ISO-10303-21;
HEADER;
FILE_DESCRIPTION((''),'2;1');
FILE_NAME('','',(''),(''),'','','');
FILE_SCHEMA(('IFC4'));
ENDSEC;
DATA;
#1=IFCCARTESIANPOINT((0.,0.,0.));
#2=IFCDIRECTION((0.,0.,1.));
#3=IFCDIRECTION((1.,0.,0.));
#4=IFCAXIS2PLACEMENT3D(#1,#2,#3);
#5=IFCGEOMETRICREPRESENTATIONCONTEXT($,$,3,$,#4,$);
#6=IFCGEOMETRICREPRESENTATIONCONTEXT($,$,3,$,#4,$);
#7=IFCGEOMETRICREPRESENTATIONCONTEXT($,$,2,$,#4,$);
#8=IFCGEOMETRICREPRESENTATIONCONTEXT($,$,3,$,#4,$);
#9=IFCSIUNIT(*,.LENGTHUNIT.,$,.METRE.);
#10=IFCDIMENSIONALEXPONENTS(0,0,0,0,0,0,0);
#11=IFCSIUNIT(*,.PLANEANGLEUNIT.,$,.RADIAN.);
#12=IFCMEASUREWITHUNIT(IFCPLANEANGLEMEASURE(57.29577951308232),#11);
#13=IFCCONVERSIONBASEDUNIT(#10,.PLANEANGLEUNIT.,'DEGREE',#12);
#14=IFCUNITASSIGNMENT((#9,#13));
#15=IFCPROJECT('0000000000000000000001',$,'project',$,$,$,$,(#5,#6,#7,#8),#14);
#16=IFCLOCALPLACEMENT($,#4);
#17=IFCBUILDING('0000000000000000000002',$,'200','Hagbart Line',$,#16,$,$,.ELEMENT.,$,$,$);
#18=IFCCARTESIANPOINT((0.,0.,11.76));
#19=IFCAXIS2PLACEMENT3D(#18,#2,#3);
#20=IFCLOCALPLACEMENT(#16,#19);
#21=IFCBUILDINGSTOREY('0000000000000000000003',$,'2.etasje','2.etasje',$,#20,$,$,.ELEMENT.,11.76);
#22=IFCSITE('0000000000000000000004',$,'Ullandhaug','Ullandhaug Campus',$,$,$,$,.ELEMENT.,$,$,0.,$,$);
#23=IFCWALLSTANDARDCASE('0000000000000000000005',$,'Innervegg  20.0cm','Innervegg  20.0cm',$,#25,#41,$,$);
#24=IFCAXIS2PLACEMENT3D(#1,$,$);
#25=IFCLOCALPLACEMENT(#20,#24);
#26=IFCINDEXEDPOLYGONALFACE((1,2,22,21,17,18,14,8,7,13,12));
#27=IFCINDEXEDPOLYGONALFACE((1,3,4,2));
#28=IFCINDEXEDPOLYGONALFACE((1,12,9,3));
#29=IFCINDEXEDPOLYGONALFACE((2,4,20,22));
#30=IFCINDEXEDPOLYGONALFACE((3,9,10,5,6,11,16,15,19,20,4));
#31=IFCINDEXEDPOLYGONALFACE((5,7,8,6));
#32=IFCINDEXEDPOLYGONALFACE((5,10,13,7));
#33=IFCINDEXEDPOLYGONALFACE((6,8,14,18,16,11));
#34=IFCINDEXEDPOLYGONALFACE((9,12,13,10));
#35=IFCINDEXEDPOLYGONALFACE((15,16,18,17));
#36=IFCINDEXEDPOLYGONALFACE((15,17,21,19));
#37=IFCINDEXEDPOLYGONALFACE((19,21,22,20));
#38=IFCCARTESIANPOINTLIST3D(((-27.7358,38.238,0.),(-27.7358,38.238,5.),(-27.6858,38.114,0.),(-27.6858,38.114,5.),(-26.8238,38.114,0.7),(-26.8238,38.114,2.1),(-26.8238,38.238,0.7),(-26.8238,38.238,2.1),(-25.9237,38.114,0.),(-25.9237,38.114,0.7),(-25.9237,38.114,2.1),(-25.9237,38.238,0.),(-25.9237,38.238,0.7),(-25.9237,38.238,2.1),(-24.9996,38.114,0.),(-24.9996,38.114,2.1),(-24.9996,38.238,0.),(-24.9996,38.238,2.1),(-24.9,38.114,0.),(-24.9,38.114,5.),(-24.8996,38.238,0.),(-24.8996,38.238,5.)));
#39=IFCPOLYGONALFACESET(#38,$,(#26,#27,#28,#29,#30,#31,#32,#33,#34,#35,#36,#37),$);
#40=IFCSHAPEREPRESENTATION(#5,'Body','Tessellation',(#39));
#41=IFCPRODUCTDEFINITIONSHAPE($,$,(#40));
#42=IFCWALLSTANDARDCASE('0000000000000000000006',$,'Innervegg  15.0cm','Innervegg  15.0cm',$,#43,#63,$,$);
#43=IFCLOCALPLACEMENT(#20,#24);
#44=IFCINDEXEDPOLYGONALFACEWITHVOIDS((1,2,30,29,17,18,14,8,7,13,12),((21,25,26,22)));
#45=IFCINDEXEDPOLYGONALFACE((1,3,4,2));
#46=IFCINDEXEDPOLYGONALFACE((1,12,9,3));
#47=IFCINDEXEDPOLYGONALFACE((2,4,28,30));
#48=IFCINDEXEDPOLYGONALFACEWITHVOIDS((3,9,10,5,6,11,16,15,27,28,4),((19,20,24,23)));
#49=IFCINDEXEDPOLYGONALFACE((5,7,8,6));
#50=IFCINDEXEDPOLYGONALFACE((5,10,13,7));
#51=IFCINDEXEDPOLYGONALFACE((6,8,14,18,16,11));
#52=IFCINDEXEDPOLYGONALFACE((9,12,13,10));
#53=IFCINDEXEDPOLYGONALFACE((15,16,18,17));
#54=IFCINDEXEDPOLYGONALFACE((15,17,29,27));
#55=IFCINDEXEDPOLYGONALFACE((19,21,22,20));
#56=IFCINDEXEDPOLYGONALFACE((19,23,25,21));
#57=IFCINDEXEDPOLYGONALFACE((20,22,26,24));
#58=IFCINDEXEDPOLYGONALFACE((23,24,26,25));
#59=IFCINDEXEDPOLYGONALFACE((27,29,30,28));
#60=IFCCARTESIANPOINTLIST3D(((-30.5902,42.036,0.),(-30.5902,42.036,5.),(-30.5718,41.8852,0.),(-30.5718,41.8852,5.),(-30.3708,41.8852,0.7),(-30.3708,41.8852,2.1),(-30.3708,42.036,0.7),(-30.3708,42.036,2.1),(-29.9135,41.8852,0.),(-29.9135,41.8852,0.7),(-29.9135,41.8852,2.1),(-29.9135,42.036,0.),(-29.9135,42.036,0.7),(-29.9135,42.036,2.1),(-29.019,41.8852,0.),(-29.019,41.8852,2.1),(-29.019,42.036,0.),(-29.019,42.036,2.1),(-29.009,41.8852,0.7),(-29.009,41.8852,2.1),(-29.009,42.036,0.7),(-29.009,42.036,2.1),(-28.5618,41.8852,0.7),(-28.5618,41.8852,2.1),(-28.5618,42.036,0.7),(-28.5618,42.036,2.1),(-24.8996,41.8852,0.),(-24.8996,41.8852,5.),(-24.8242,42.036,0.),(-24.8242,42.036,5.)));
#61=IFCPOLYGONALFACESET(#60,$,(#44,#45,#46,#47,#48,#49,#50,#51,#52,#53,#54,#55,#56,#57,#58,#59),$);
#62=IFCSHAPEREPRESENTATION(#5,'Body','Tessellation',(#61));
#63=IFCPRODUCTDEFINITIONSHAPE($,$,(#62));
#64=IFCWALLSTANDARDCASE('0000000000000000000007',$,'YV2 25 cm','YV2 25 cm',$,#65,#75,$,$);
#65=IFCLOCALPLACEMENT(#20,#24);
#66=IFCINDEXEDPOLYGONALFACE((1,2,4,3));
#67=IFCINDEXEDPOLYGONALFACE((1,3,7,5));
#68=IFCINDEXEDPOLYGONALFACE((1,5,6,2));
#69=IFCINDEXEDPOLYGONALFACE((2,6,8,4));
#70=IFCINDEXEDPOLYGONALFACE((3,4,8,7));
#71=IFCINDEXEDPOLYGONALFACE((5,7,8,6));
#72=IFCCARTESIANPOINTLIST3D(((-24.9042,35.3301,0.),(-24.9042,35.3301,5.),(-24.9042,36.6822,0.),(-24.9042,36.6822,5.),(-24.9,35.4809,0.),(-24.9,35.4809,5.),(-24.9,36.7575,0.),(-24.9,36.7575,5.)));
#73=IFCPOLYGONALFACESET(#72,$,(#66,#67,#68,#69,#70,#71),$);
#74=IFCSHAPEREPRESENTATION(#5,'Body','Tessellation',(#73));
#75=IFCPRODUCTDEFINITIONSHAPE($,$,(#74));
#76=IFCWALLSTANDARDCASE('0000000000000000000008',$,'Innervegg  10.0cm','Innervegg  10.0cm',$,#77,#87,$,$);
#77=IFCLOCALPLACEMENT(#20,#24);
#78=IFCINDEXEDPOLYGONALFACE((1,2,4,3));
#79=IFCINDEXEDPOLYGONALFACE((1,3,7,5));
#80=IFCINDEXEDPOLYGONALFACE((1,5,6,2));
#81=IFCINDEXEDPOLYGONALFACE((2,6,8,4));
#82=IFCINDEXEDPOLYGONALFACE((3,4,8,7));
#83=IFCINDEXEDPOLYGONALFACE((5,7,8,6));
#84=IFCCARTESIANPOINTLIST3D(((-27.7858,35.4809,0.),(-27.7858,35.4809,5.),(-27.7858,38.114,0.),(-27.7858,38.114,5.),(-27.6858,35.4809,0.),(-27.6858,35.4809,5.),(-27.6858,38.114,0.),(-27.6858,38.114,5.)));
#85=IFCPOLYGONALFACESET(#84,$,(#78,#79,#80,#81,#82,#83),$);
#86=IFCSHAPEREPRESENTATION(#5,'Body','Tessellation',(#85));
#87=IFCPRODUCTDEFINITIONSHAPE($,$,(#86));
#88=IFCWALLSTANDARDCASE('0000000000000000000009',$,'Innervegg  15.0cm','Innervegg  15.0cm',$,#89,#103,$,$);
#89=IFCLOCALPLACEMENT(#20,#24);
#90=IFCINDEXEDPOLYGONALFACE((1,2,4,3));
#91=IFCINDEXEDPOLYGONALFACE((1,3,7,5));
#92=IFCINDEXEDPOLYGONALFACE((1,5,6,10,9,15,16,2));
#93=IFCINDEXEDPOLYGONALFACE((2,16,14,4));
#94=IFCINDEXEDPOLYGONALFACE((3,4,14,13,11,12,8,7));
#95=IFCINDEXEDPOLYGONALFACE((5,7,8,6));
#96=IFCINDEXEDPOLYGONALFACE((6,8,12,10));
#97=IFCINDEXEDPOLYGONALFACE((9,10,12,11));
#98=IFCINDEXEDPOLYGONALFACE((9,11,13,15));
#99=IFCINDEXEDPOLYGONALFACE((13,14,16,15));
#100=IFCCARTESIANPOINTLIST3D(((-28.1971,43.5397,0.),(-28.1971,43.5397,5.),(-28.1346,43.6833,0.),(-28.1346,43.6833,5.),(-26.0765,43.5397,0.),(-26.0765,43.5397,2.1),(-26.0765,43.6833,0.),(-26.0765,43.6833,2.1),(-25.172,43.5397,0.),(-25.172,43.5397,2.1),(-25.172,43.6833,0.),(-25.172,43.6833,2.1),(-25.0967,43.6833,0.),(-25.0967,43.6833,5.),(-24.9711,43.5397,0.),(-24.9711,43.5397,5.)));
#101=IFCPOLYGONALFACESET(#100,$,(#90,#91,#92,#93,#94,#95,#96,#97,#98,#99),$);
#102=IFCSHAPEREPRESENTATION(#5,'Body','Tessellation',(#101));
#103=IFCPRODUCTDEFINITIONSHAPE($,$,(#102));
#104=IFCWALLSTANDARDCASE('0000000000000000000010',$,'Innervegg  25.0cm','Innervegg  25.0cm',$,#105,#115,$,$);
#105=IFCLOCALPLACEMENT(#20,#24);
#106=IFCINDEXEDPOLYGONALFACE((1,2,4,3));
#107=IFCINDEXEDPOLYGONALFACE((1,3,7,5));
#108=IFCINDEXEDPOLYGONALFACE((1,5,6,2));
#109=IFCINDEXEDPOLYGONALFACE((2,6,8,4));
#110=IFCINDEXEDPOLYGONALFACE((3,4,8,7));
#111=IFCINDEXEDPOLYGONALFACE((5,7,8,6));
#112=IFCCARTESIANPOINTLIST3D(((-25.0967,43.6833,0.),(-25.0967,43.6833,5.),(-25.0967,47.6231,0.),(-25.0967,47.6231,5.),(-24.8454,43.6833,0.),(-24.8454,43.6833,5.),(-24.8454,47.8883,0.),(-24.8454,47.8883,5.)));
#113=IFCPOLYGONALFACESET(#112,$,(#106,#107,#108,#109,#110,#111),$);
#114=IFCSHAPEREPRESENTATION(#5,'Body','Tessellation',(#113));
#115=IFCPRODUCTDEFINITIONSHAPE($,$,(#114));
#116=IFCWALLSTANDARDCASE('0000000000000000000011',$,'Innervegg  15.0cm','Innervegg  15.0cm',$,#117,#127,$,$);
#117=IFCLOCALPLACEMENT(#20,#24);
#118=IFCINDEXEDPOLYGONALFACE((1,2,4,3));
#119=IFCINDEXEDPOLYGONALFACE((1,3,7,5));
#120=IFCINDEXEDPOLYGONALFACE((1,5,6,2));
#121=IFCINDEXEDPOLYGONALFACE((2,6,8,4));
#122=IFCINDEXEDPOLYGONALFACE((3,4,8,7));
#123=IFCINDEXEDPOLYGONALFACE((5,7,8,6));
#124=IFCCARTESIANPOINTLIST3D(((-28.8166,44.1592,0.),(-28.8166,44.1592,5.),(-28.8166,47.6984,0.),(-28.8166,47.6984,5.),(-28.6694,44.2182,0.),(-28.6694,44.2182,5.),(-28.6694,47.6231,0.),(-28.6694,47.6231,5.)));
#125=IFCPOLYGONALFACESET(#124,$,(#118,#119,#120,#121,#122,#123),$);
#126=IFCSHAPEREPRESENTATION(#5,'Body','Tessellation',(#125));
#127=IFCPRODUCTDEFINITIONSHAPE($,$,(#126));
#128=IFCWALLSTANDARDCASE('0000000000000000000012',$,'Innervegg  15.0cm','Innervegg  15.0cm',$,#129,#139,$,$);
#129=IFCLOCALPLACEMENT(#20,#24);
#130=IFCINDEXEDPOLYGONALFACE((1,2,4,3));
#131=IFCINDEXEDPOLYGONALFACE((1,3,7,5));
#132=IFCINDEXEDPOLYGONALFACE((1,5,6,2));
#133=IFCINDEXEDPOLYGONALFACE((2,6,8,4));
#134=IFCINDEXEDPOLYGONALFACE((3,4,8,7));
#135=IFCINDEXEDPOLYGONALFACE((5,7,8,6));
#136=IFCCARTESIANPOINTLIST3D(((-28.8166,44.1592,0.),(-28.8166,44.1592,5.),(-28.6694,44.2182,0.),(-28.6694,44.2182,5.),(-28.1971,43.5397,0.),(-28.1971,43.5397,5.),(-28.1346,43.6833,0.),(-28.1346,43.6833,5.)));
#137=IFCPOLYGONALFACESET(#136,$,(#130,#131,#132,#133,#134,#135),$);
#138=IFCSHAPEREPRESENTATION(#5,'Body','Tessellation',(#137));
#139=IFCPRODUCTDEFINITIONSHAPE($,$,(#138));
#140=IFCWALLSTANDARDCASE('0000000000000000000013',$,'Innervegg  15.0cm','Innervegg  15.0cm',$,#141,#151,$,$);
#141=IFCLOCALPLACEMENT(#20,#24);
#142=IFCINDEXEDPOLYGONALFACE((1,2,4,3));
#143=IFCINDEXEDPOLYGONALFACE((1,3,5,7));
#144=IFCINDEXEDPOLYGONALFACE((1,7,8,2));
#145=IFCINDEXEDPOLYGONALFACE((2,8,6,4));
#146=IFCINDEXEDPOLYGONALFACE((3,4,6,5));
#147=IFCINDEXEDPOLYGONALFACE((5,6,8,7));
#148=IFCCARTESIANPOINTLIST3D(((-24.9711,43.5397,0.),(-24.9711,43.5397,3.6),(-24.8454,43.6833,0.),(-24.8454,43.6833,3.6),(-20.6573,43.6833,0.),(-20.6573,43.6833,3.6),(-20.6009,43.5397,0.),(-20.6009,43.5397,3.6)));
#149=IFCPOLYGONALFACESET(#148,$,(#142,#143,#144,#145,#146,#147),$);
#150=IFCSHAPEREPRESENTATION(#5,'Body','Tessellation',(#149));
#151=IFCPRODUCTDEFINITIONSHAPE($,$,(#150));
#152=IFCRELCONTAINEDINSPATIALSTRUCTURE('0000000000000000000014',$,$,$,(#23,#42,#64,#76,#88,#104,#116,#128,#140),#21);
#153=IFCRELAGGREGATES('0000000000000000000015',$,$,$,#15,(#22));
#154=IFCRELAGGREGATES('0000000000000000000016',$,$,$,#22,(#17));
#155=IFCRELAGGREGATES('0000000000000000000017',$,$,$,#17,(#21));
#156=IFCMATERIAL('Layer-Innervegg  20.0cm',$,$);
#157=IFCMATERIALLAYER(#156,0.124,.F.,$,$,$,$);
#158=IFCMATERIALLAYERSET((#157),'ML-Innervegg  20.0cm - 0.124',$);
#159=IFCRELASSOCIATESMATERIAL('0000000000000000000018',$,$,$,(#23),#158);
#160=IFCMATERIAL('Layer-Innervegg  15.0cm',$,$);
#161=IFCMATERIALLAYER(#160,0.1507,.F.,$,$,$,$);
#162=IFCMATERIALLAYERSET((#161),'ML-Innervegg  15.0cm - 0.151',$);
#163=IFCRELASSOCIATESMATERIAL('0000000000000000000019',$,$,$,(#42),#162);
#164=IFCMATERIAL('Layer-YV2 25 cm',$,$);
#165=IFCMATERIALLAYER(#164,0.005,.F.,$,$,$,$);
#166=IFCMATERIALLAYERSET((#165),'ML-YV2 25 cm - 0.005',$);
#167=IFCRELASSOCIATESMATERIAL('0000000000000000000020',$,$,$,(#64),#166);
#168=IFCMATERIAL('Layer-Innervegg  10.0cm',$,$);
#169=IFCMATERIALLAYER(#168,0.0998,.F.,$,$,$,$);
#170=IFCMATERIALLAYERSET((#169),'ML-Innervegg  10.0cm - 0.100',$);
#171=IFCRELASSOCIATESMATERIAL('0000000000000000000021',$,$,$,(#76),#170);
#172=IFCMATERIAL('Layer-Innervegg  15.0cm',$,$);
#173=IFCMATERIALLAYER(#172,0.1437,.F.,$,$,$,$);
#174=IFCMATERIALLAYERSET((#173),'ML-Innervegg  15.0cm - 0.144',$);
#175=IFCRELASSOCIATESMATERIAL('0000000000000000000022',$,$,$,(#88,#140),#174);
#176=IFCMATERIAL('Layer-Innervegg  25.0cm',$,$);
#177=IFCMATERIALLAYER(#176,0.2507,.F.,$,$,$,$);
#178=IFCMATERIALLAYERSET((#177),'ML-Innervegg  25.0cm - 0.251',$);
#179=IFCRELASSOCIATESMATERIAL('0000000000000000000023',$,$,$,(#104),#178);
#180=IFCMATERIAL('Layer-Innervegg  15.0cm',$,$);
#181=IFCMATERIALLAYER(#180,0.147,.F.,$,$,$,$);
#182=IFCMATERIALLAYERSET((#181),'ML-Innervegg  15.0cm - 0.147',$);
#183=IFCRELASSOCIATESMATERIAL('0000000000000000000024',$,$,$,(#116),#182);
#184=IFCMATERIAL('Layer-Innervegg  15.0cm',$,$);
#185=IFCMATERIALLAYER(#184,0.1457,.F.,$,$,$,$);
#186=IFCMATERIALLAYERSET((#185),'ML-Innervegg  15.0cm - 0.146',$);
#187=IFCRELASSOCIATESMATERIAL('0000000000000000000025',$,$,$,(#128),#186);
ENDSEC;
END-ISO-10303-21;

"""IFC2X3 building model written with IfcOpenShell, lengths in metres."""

from ifc_helpers import new_model, entity, si_unit, converted_unit, frame, origin_with_axes, place, context, project, spatial, polyline, outline, extrude, material, layer, layer_set, layer_usage, element, save


model = new_model("IFC2X3")

# Units and contexts
context_of_model_1 = context(None, 3, world=origin_with_axes())
context_of_model_2 = context(None, 3, world=origin_with_axes())
context_of_model_3 = context(None, 2, world=origin_with_axes())
context_of_model_4 = context(None, 3, world=origin_with_axes())
ifc_project = project(units=[si_unit("LENGTHUNIT", "METRE"), converted_unit("PLANEANGLEUNIT", "DEGREE", entity("IfcPlaneAngleMeasure", 57.29577951308232), si_unit("PLANEANGLEUNIT", "RADIAN"), dimensions=[0, 0, 0, 0, 0, 0, 0])], contexts=[context_of_model_1, context_of_model_2, context_of_model_3, context_of_model_4])

# Site, building, storey
site = spatial("IfcSite", under=ifc_project, Name="Ullandhaug", Description="Ullandhaug Campus", CompositionType="ELEMENT", RefElevation=0.0)
building_placement = place(None, origin_with_axes())
building = spatial("IfcBuilding", under=site, at=building_placement, Name="200", Description="Hagbart Line", CompositionType="ELEMENT")
storey_placement = place(building_placement, frame((0.0, 0.0, 11.76), z_axis=(0.0, 0.0, 1.0), x_axis=(1.0, 0.0, 0.0)))
storey = spatial("IfcBuildingStorey", under=building, at=storey_placement, Name="2.etasje", Description="2.etasje", CompositionType="ELEMENT", Elevation=11.76)

# Shared definitions
ifc_material_1 = material(Name="Layer-Innervegg  15.0cm")
ifc_layer_1 = layer(ifc_material_1, 0.1507, ventilated=False)
ifc_layer_set_1 = layer_set([ifc_layer_1], Name="ML-Innervegg  15.0cm - 0.151")
ifc_layer_usage_1 = layer_usage(ifc_layer_set_1, "AXIS2", "POSITIVE", 0.0)

# Walls, openings
ifc_material_2 = material(Name="Layer-Innervegg  20.0cm")
ifc_layer_2 = layer(ifc_material_2, 0.124, ventilated=False)
ifc_layer_set_2 = layer_set([ifc_layer_2], Name="ML-Innervegg  20.0cm - 0.124")
ifc_layer_usage_2 = layer_usage(ifc_layer_set_2, "AXIS2", "POSITIVE", 0.0)
wall_1_placement = place(storey_placement, frame((-27.6858, 38.114, 0.0), z_axis=(0.0, 0.0, 1.0), x_axis=(1.0, 0.0, 0.0)))
wall_1 = element("IfcWallStandardCase", 1, at=wall_1_placement, inside=storey, material=ifc_layer_usage_2, Name="Innervegg  20.0cm", Description="Innervegg  20.0cm", context=context_of_model_1, shape_type="SweptSolid", body=[
    extrude(outline(polyline([(0.0, 0.0), (2.7858, 0.0), (2.7862, 0.124), (-0.05, 0.124), (0.0, 0.0)])), origin_with_axes(), (0.0, 0.0, 1.0), 5.0),
])
opening_1_placement = place(wall_1_placement, frame((0.862, 0.124, 0.7), z_axis=(0.0, 0.0, 1.0), x_axis=(1.0, 0.0, 0.0)))
element("IfcOpeningElement", 2, at=opening_1_placement, cuts=wall_1, context=context_of_model_1, shape_type="SweptSolid", body=[
    extrude(outline(polyline([(0.0, 0.0), (1.4, 0.0), (1.4, 0.9001), (0.0, 0.9001), (0.0, 0.0)])), frame((0.0, 0.0, 0.0), z_axis=(0.0, 1.0, 0.0), x_axis=(0.0, 0.0, 1.0)), (0.0, 0.0, -1.0), 0.124),
])
opening_2_placement = place(wall_1_placement, frame((1.7621, 0.124, 0.0), z_axis=(0.0, 0.0, 1.0), x_axis=(1.0, 0.0, 0.0)))
element("IfcOpeningElement", 3, at=opening_2_placement, cuts=wall_1, context=context_of_model_1, shape_type="SweptSolid", body=[
    extrude(outline(polyline([(0.0, 0.0), (2.1, 0.0), (2.1, 0.9241), (0.0, 0.9241), (0.0, 0.0)])), frame((0.0, 0.0, 0.0), z_axis=(0.0, 1.0, 0.0), x_axis=(0.0, 0.0, 1.0)), (0.0, 0.0, -1.0), 0.124),
])
wall_2_placement = place(storey_placement, frame((-24.8242, 42.036, 0.0), z_axis=(0.0, 0.0, 1.0), x_axis=(-1.0, 0.0, 0.0)))
wall_2 = element("IfcWallStandardCase", 4, at=wall_2_placement, inside=storey, material=ifc_layer_usage_1, Name="Innervegg  15.0cm", Description="Innervegg  15.0cm", context=context_of_model_1, shape_type="SweptSolid", body=[
    extrude(outline(polyline([(0.0, 0.0), (5.766, 0.0), (5.7476, 0.1508), (0.0754, 0.1508), (0.0, 0.0)])), frame((0.0, 0.0, 0.0), z_axis=(0.0, 0.0, 1.0), x_axis=(1.0, 0.0, 0.0)), (0.0, 0.0, 1.0), 5.0),
])
opening_3_placement = place(wall_2_placement, frame((4.1948, 0.1508, 0.0), z_axis=(0.0, 0.0, 1.0), x_axis=(1.0, 0.0, 0.0)))
element("IfcOpeningElement", 5, at=opening_3_placement, cuts=wall_2, context=context_of_model_1, shape_type="SweptSolid", body=[
    extrude(outline(polyline([(0.0, 0.0), (2.1, 0.0), (2.1, 0.8944), (0.0, 0.8944), (0.0, 0.0)])), frame((0.0, 0.0, 0.0), z_axis=(0.0, 1.0, 0.0), x_axis=(0.0, 0.0, 1.0)), (0.0, 0.0, -1.0), 0.1508),
])
opening_4_placement = place(wall_2_placement, frame((5.0893, 0.1508, 0.7), z_axis=(0.0, 0.0, 1.0), x_axis=(1.0, 0.0, 0.0)))
element("IfcOpeningElement", 6, at=opening_4_placement, cuts=wall_2, context=context_of_model_1, shape_type="SweptSolid", body=[
    extrude(outline(polyline([(0.0, 0.0), (1.4, 0.0), (1.4, 0.4573), (0.0, 0.4573), (0.0, 0.0)])), frame((0.0, 0.0, 0.0), z_axis=(0.0, 1.0, 0.0), x_axis=(0.0, 0.0, 1.0)), (0.0, 0.0, -1.0), 0.1508),
])
opening_5_placement = place(wall_2_placement, frame((3.7376, 0.1508, 0.7), z_axis=(0.0, 0.0, 1.0), x_axis=(1.0, 0.0, 0.0)))
element("IfcOpeningElement", 7, at=opening_5_placement, cuts=wall_2, context=context_of_model_1, shape_type="SweptSolid", body=[
    extrude(outline(polyline([(0.0, 0.0), (1.4, 0.0), (1.4, 0.4472), (0.0, 0.4472), (0.0, 0.0)])), frame((0.0, 0.0, 0.0), z_axis=(0.0, 1.0, 0.0), x_axis=(0.0, 0.0, 1.0)), (0.0, 0.0, -1.0), 0.1508),
])

# Walls
ifc_material_3 = material(Name="Layer-YV2 25 cm")
ifc_layer_3 = layer(ifc_material_3, 0.005, ventilated=False)
ifc_layer_set_3 = layer_set([ifc_layer_3], Name="ML-YV2 25 cm - 0.005")
ifc_layer_usage_3 = layer_usage(ifc_layer_set_3, "AXIS2", "POSITIVE", 0.0)
wall_3_placement = place(storey_placement, frame((-24.9, 35.4809, 0.0), z_axis=(0.0, 0.0, 1.0), x_axis=(0.0, 1.0, 0.0)))
element("IfcWallStandardCase", 8, at=wall_3_placement, inside=storey, material=ifc_layer_usage_3, Name="YV2 25 cm", Description="YV2 25 cm", context=context_of_model_1, shape_type="SweptSolid", body=[
    extrude(outline(polyline([(0.0, 0.0), (1.2766, 0.0), (1.2013, 0.0042), (-0.1508, 0.0042), (0.0, 0.0)])), frame((0.0, 0.0, 0.0), z_axis=(0.0, 0.0, 1.0), x_axis=(1.0, 0.0, 0.0)), (0.0, 0.0, 1.0), 5.0),
])
ifc_material_4 = material(Name="Layer-Innervegg  10.0cm")
ifc_layer_4 = layer(ifc_material_4, 0.0998, ventilated=False)
ifc_layer_set_4 = layer_set([ifc_layer_4], Name="ML-Innervegg  10.0cm - 0.100")
ifc_layer_usage_4 = layer_usage(ifc_layer_set_4, "AXIS2", "POSITIVE", 0.0)
wall_4_placement = place(storey_placement, frame((-27.7858, 38.114, 0.0), z_axis=(0.0, 0.0, 1.0), x_axis=(0.0, -1.0, 0.0)))
element("IfcWallStandardCase", 9, at=wall_4_placement, inside=storey, material=ifc_layer_usage_4, Name="Innervegg  10.0cm", Description="Innervegg  10.0cm", context=context_of_model_1, shape_type="SweptSolid", body=[
    extrude(outline(polyline([(0.0, 0.0), (2.6331, 0.0), (2.6331, 0.1), (0.0, 0.1), (0.0, 0.0)])), frame((0.0, 0.0, 0.0), z_axis=(0.0, 0.0, 1.0), x_axis=(1.0, 0.0, 0.0)), (0.0, 0.0, 1.0), 5.0),
])

# Wall, opening
ifc_material_5 = material(Name="Layer-Innervegg  15.0cm")
ifc_layer_5 = layer(ifc_material_5, 0.1437, ventilated=False)
ifc_layer_set_5 = layer_set([ifc_layer_5], Name="ML-Innervegg  15.0cm - 0.144")
ifc_layer_usage_5 = layer_usage(ifc_layer_set_5, "AXIS2", "POSITIVE", 0.0)
wall_5_placement = place(storey_placement, frame((-28.1971, 43.5397, 0.0), z_axis=(0.0, 0.0, 1.0), x_axis=(1.0, 0.0, 0.0)))
wall_5 = element("IfcWallStandardCase", 10, at=wall_5_placement, inside=storey, material=ifc_layer_usage_5, Name="Innervegg  15.0cm", Description="Innervegg  15.0cm", context=context_of_model_1, shape_type="SweptSolid", body=[
    extrude(outline(polyline([(0.0, 0.0), (3.226, 0.0), (3.1004, 0.1437), (0.0624, 0.1437), (0.0, 0.0)])), origin_with_axes(), (0.0, 0.0, 1.0), 5.0),
])
opening_6_placement = place(wall_5_placement, frame((2.1205, 0.1437, 0.0), z_axis=(0.0, 0.0, 1.0), x_axis=(1.0, 0.0, 0.0)))
element("IfcOpeningElement", 11, at=opening_6_placement, cuts=wall_5, context=context_of_model_1, shape_type="SweptSolid", body=[
    extrude(outline(polyline([(0.0, 0.0), (2.1, 0.0), (2.1, 0.9045), (0.0, 0.9045), (0.0, 0.0)])), frame((0.0, 0.0, 0.0), z_axis=(0.0, 1.0, 0.0), x_axis=(0.0, 0.0, 1.0)), (0.0, 0.0, -1.0), 0.1437),
])

# Walls
ifc_material_6 = material(Name="Layer-Innervegg  25.0cm")
ifc_layer_6 = layer(ifc_material_6, 0.2507, ventilated=False)
ifc_layer_set_6 = layer_set([ifc_layer_6], Name="ML-Innervegg  25.0cm - 0.251")
ifc_layer_usage_6 = layer_usage(ifc_layer_set_6, "AXIS2", "POSITIVE", 0.0)
wall_6_placement = place(storey_placement, frame((-24.8454, 43.6833, 0.0), z_axis=(0.0, 0.0, 1.0), x_axis=(0.0, 1.0, 0.0)))
element("IfcWallStandardCase", 12, at=wall_6_placement, inside=storey, material=ifc_layer_usage_6, Name="Innervegg  25.0cm", Description="Innervegg  25.0cm", context=context_of_model_1, shape_type="SweptSolid", body=[
    extrude(outline(polyline([(0.0, 0.0), (4.2049, 0.0), (3.9397, 0.2512), (0.0, 0.2512), (0.0, 0.0)])), frame((0.0, 0.0, 0.0), z_axis=(0.0, 0.0, 1.0), x_axis=(1.0, 0.0, 0.0)), (0.0, 0.0, 1.0), 5.0),
])
ifc_material_7 = material(Name="Layer-Innervegg  15.0cm")
ifc_layer_7 = layer(ifc_material_7, 0.147, ventilated=False)
ifc_layer_set_7 = layer_set([ifc_layer_7], Name="ML-Innervegg  15.0cm - 0.147")
ifc_layer_usage_7 = layer_usage(ifc_layer_set_7, "AXIS2", "POSITIVE", 0.0)
wall_7_placement = place(storey_placement, frame((-28.8166, 47.6984, 0.0), z_axis=(0.0, 0.0, 1.0), x_axis=(0.0, -1.0, 0.0)))
element("IfcWallStandardCase", 13, at=wall_7_placement, inside=storey, material=ifc_layer_usage_7, Name="Innervegg  15.0cm", Description="Innervegg  15.0cm", context=context_of_model_1, shape_type="SweptSolid", body=[
    extrude(outline(polyline([(0.0, 0.0), (3.5392, 0.0), (3.4803, 0.1472), (0.0754, 0.1472), (0.0, 0.0)])), frame((0.0, 0.0, 0.0), z_axis=(0.0, 0.0, 1.0), x_axis=(1.0, 0.0, 0.0)), (0.0, 0.0, 1.0), 5.0),
])
ifc_material_8 = material(Name="Layer-Innervegg  15.0cm")
ifc_layer_8 = layer(ifc_material_8, 0.1457, ventilated=False)
ifc_layer_set_8 = layer_set([ifc_layer_8], Name="ML-Innervegg  15.0cm - 0.146")
ifc_layer_usage_8 = layer_usage(ifc_layer_set_8, "AXIS2", "POSITIVE", 0.0)
wall_8_placement = place(storey_placement, frame((-28.8166, 44.1592, 0.0), z_axis=(0.0, 0.0, 1.0), x_axis=(0.707108, -0.707106, 0.0)))
element("IfcWallStandardCase", 14, at=wall_8_placement, inside=storey, material=ifc_layer_usage_8, Name="Innervegg  15.0cm", Description="Innervegg  15.0cm", context=context_of_model_1, shape_type="SweptSolid", body=[
    extrude(outline(polyline([(0.0, 0.0), (0.8762, 0.0), (0.8188, 0.1457), (0.0624, 0.1457), (0.0, 0.0)])), frame((0.0, 0.0, 0.0), z_axis=(0.0, 0.0, 1.0), x_axis=(1.0, 0.0, 0.0)), (0.0, 0.0, 1.0), 5.0),
])
wall_9_placement = place(storey_placement, frame((-24.9711, 43.5397, 0.0), z_axis=(0.0, 0.0, 1.0), x_axis=(1.0, 0.0, 0.0)))
element("IfcWallStandardCase", 15, at=wall_9_placement, inside=storey, material=ifc_layer_usage_5, Name="Innervegg  15.0cm", Description="Innervegg  15.0cm", context=context_of_model_1, shape_type="SweptSolid", body=[
    extrude(outline(polyline([(0.0, 0.0), (4.3701, 0.0), (4.3138, 0.1437), (0.1256, 0.1437), (0.0, 0.0)])), origin_with_axes(), (0.0, 0.0, 1.0), 3.6),
])

save(model, "model.ifc")
